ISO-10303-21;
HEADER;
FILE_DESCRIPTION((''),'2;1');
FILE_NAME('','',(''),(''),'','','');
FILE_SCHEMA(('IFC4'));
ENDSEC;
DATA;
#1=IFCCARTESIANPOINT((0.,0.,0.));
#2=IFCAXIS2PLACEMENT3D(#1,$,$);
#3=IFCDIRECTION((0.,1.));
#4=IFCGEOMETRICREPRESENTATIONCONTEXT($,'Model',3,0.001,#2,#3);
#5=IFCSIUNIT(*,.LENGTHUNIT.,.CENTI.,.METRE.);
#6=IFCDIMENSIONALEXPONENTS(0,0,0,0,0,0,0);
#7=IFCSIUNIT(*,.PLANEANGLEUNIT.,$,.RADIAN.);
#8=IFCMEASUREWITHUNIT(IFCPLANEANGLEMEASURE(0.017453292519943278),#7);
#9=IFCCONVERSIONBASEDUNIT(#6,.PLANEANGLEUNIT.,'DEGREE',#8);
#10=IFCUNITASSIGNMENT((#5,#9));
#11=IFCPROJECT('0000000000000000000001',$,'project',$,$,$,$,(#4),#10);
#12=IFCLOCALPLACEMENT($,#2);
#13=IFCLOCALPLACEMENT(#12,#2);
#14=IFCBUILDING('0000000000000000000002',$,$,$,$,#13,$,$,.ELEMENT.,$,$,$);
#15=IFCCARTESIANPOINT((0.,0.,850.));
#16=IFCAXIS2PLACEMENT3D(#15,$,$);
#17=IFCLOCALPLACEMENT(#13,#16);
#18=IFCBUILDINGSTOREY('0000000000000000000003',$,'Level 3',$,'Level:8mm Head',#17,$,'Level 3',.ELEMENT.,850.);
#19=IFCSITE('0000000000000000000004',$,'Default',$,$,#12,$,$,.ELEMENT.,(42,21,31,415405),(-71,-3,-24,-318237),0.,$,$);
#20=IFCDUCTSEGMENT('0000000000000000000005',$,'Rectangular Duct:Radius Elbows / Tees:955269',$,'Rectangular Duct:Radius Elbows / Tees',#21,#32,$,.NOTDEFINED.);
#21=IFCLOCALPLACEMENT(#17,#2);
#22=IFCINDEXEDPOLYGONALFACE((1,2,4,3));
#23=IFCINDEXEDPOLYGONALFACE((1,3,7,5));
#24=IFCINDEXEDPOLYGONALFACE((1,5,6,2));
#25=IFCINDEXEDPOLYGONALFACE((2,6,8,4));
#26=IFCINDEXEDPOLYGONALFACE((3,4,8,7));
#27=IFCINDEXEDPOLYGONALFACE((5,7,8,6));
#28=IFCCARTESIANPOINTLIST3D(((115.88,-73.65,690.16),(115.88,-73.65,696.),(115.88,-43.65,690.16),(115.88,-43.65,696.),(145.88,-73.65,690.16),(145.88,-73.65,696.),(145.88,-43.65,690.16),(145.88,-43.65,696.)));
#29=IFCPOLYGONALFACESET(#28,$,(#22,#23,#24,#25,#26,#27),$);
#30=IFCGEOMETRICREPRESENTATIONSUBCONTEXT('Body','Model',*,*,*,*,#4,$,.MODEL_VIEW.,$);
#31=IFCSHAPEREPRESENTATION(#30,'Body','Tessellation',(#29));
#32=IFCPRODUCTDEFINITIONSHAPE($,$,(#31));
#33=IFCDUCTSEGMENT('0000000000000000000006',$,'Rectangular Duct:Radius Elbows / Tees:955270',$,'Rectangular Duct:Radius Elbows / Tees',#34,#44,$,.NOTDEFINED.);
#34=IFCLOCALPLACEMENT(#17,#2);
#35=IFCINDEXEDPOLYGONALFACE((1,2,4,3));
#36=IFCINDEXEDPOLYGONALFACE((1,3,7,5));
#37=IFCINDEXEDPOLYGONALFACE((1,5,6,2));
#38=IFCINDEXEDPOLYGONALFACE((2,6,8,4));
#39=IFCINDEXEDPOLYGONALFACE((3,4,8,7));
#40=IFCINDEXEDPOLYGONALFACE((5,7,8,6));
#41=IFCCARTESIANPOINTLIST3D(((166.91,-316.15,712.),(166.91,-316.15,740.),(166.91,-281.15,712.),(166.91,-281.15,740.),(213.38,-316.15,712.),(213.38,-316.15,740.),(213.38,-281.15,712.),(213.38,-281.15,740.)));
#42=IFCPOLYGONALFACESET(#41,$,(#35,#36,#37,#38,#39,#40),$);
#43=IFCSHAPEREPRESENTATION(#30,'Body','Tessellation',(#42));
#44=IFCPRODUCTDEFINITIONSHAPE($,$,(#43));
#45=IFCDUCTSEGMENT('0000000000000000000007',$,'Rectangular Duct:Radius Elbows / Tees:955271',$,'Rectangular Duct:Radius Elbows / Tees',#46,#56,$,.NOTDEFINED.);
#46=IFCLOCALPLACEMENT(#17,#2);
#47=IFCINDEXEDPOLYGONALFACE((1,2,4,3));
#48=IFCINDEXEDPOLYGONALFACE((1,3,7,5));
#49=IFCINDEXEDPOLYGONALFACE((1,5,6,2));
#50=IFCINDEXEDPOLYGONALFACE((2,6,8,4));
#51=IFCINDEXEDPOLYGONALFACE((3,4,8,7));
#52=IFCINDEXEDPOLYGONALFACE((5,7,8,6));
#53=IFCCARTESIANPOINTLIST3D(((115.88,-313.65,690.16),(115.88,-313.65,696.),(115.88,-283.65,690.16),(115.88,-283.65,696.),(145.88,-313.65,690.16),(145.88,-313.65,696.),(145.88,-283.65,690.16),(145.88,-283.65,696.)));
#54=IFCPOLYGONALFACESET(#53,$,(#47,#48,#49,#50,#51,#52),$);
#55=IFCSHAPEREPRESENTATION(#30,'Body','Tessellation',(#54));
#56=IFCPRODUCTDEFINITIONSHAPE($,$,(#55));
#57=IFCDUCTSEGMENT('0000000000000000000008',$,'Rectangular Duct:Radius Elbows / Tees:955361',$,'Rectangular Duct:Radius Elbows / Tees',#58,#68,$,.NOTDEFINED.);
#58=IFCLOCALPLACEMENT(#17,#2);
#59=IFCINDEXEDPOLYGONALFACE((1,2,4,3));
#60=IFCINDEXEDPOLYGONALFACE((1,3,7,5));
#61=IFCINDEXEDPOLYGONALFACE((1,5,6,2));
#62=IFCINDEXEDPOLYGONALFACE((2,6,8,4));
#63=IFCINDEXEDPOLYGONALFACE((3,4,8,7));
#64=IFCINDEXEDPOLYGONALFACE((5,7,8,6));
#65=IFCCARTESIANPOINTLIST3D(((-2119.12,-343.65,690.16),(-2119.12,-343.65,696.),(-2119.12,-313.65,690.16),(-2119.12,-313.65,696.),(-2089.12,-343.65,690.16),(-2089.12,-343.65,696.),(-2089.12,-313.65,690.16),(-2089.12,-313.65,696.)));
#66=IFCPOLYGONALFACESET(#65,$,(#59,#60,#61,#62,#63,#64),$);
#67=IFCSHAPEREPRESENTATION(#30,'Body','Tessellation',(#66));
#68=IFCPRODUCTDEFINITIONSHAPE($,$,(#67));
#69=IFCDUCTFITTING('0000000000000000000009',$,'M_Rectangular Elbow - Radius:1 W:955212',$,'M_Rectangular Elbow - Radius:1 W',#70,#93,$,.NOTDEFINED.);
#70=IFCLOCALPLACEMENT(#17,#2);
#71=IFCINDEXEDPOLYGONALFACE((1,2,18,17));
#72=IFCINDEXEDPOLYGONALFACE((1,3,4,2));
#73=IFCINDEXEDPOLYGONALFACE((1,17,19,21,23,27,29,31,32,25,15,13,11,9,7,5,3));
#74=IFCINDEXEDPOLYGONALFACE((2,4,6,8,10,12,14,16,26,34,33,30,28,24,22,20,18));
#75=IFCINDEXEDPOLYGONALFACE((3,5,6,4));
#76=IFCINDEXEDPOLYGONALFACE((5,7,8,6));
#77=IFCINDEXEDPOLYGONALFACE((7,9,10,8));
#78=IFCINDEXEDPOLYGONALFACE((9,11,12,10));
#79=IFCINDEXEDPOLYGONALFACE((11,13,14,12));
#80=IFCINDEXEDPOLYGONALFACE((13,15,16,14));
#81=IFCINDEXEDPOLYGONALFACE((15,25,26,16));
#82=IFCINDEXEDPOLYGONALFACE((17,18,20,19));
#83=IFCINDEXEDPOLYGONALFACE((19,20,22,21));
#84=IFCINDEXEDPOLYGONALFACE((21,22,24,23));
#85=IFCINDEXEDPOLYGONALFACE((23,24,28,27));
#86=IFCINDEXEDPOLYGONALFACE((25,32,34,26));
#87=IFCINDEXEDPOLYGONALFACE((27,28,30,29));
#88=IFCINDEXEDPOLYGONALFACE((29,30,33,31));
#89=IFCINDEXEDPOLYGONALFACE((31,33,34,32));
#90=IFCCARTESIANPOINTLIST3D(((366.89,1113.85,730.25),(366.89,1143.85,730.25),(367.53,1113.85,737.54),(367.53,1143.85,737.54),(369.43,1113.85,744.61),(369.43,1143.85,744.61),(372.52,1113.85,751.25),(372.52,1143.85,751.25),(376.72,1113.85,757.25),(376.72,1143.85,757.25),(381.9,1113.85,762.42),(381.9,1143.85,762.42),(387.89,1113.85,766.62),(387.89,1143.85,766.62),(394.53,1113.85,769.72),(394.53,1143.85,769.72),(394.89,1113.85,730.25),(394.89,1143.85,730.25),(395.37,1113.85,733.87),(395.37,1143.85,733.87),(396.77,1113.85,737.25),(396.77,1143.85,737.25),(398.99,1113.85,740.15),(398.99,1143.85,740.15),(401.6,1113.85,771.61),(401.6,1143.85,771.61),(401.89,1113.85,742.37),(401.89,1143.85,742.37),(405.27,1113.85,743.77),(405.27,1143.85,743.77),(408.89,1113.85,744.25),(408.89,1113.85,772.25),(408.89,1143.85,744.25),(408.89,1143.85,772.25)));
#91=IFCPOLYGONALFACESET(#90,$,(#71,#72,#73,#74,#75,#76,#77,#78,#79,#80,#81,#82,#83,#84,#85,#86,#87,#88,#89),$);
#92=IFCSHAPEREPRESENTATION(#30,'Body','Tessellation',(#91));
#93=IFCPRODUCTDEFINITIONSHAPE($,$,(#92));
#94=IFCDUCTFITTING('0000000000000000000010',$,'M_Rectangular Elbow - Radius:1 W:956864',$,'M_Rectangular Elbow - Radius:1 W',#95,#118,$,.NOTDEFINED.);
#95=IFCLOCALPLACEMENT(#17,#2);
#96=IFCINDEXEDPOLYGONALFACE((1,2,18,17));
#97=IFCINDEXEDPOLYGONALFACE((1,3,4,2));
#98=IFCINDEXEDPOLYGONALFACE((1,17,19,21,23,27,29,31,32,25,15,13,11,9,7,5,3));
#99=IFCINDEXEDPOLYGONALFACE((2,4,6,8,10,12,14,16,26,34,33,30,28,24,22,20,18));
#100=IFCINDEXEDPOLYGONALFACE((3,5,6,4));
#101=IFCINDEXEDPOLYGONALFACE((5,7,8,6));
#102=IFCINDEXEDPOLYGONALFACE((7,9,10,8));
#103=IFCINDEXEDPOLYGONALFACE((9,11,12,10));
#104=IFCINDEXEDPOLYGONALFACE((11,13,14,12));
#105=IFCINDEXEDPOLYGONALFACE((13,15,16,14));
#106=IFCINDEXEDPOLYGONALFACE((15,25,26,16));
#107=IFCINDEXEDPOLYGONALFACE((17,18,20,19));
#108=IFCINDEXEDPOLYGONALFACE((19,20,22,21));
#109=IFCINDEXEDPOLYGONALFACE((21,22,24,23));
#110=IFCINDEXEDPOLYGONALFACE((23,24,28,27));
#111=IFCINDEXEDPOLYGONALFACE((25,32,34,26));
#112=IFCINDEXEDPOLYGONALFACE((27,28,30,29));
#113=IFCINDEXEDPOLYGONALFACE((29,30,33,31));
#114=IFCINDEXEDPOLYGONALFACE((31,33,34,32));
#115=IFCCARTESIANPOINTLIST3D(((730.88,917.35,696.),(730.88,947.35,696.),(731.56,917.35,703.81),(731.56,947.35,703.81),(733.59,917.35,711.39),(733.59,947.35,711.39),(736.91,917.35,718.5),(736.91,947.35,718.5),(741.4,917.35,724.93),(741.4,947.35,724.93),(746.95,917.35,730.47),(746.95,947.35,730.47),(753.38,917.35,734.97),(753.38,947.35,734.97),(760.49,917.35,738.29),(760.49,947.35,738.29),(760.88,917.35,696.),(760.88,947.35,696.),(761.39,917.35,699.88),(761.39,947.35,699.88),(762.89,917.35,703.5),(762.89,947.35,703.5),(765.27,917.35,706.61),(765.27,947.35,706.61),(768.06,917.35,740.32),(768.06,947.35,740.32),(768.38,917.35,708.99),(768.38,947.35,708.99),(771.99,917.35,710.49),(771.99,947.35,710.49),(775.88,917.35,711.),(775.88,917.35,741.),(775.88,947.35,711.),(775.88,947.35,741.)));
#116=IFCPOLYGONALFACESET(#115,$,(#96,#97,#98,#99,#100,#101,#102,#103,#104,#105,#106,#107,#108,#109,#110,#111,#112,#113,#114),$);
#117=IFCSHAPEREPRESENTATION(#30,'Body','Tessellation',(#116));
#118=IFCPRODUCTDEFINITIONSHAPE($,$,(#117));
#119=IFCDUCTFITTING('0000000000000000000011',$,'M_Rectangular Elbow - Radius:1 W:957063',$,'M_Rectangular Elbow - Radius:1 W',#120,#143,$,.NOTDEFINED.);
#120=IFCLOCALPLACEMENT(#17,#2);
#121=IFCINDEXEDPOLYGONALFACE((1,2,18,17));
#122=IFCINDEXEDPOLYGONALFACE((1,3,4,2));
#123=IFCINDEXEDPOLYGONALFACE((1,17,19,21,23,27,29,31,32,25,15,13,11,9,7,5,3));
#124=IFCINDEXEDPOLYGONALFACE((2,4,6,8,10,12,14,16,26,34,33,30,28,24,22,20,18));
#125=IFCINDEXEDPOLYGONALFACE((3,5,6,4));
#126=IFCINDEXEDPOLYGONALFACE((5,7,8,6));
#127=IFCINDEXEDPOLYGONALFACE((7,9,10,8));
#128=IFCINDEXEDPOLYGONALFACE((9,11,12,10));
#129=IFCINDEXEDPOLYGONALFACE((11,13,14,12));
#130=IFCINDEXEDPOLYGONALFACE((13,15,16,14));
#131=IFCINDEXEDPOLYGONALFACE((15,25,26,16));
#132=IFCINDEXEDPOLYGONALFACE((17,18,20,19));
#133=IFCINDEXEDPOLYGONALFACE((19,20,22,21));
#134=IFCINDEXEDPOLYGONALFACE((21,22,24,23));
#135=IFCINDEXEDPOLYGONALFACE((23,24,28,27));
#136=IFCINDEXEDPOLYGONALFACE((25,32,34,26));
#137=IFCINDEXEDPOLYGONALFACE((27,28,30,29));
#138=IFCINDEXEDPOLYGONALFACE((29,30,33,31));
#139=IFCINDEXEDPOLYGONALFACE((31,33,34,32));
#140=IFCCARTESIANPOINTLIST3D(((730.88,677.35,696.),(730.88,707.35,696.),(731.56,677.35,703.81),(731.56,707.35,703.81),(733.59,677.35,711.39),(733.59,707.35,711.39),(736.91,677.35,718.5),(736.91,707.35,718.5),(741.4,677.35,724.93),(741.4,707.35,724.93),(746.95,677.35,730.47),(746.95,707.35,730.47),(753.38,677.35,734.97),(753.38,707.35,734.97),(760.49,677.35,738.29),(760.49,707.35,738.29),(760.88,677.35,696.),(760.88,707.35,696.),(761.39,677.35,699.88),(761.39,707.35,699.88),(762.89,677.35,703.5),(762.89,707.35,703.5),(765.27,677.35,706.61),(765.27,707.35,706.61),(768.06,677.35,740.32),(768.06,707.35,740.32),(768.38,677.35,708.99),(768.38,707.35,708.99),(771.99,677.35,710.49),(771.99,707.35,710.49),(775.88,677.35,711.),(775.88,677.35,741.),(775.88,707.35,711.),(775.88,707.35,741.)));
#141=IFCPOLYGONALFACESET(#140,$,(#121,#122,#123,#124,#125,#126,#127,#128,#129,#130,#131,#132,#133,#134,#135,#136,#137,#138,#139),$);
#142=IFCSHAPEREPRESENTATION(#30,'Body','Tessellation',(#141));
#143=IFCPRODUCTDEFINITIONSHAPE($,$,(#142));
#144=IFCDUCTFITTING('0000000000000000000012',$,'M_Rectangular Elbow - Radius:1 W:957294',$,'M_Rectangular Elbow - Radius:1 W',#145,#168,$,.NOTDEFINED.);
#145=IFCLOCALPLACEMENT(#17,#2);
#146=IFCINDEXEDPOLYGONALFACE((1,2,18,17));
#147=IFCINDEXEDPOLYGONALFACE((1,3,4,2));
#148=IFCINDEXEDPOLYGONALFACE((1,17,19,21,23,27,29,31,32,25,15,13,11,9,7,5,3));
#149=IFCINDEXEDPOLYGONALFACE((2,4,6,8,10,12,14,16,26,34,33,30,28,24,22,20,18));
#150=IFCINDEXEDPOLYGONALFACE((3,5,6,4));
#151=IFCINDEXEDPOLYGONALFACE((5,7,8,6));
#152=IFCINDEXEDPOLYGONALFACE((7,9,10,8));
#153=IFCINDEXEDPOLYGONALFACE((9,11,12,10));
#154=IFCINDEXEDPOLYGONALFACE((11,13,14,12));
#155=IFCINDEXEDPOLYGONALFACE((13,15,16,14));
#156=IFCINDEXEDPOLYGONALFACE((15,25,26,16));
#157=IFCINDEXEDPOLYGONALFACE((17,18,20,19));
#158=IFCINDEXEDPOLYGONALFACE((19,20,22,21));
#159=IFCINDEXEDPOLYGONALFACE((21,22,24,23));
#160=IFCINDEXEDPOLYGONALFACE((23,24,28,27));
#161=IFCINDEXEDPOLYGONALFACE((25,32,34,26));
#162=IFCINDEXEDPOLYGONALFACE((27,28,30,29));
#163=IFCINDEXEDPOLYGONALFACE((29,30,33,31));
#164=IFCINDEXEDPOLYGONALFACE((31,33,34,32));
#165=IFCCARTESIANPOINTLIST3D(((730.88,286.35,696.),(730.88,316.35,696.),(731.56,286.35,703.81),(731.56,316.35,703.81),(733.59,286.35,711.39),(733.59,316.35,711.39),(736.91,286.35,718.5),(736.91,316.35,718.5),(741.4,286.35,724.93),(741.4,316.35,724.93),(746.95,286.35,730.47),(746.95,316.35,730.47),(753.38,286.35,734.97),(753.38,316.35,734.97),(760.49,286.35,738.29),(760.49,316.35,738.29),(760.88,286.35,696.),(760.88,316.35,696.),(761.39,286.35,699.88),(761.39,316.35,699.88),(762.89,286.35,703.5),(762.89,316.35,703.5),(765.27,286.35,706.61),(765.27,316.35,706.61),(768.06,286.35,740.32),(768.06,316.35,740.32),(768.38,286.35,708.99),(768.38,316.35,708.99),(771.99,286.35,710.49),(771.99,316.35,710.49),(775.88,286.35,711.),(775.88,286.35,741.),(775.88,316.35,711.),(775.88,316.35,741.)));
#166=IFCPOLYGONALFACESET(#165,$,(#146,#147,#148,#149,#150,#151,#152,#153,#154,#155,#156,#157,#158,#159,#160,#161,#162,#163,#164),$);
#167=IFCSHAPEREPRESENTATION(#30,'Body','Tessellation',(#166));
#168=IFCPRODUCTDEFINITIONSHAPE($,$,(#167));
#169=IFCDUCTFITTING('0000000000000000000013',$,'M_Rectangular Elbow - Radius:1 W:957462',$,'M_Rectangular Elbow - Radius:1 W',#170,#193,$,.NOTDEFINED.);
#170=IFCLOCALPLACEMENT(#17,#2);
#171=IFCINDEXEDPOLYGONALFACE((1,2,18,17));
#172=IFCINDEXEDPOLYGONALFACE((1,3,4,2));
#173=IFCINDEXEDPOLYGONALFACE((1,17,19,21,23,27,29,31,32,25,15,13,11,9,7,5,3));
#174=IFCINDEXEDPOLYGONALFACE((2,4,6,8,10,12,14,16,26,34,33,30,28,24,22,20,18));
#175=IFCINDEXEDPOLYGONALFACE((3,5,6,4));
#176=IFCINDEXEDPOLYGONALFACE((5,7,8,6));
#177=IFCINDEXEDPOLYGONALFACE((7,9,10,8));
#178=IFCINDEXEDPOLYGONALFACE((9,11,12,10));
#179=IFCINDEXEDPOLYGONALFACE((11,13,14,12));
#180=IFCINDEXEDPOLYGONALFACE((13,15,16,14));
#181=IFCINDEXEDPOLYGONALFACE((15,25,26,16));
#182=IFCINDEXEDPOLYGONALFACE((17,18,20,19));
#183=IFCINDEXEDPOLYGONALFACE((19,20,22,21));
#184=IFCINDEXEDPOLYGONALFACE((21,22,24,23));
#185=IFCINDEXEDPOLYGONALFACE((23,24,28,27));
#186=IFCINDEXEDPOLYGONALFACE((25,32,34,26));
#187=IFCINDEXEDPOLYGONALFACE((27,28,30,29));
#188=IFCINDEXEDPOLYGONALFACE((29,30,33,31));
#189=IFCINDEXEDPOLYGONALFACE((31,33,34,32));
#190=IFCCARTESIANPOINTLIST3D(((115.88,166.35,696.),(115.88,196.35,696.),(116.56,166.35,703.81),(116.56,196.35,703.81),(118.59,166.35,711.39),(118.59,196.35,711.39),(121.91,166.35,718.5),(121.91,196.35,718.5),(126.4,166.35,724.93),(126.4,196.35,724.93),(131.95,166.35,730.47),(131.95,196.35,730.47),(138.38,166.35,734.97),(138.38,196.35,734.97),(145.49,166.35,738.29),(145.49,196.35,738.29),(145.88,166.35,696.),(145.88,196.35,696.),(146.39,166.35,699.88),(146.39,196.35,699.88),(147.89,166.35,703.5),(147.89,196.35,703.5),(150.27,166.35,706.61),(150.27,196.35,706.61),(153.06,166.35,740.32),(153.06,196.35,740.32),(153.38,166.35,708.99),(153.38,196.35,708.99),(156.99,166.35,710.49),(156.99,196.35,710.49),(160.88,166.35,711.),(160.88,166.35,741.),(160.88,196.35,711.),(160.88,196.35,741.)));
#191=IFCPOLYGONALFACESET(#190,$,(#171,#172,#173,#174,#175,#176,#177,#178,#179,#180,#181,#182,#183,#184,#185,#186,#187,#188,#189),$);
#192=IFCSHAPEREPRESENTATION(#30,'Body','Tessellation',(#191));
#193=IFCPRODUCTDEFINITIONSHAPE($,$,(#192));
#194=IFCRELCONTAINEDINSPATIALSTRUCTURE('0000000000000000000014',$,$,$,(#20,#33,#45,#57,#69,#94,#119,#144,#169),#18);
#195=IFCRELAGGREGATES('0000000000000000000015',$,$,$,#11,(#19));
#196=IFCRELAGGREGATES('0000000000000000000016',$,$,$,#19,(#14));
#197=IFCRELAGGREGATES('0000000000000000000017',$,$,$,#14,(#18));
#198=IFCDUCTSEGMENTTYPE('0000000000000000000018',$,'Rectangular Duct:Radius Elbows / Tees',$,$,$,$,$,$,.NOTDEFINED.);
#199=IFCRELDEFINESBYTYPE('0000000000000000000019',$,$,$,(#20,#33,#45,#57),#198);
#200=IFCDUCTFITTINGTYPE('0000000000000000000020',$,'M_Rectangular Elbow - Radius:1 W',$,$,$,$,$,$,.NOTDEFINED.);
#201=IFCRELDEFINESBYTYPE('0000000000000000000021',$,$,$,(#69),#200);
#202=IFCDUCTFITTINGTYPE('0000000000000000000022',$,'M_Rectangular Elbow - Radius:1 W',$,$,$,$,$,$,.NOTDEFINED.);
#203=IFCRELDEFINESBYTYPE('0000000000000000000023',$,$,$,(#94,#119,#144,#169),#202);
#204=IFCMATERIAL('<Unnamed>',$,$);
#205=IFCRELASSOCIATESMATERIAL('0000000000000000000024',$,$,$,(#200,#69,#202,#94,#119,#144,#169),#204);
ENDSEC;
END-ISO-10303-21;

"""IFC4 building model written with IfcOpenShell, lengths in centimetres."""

from ifc_helpers import new_model, entity, si_unit, converted_unit, direction, frame, origin, place, context, subcontext, project, spatial, line, arc, indexed_curve, outline, extrude, source, transform, mapped, material, type_object, type_shapes, element, save


model = new_model("IFC4")

# Units and contexts
model_context = context("Model", 3, precision=0.001, world=origin(), true_north=direction((0.0, 1.0)))
body_context = subcontext(model_context, "Body", "Model", "MODEL_VIEW")
ifc_project = project(units=[si_unit("LENGTHUNIT", "METRE", prefix="CENTI"), converted_unit("PLANEANGLEUNIT", "DEGREE", entity("IfcPlaneAngleMeasure", 0.017453292519943278), si_unit("PLANEANGLEUNIT", "RADIAN"), dimensions=[0, 0, 0, 0, 0, 0, 0])], contexts=[model_context])

# Site, building, storey
site_placement = place(None, origin())
site = spatial("IfcSite", under=ifc_project, at=site_placement, Name="Default", CompositionType="ELEMENT", RefLatitude=(42, 21, 31, 415405), RefLongitude=(-71, -3, -24, -318237), RefElevation=0.0)
building_placement = place(site_placement, origin())
building = spatial("IfcBuilding", under=site, at=building_placement, CompositionType="ELEMENT")
storey_placement = place(building_placement, frame((0.0, 0.0, 850.0)))
storey = spatial("IfcBuildingStorey", under=building, at=storey_placement, Name="Level 3", ObjectType="Level:8mm Head", LongName="Level 3", CompositionType="ELEMENT", Elevation=850.0)

# Duct segments
duct_segment_type_1 = type_object("IfcDuctSegmentType", Name="Rectangular Duct:Radius Elbows / Tees", PredefinedType="NOTDEFINED")
duct_segment_1_placement = place(storey_placement, origin())
element("IfcDuctSegment", 1, at=duct_segment_1_placement, inside=storey, type_object=duct_segment_type_1, Name="Rectangular Duct:Radius Elbows / Tees:955269", ObjectType="Rectangular Duct:Radius Elbows / Tees", PredefinedType="NOTDEFINED", context=body_context, shape_type="SweptSolid", body=[
    extrude(outline(indexed_curve([(-15.0, -15.0), (15.0, -15.0), (15.0, 15.0), (-15.0, 15.0), (-15.0, -15.0)], self_intersect=False)), frame((130.88, -58.65, 690.16)), (0.0, 0.0, 1.0), 5.84),
])
duct_segment_2_placement = place(storey_placement, origin())
element("IfcDuctSegment", 2, at=duct_segment_2_placement, inside=storey, type_object=duct_segment_type_1, Name="Rectangular Duct:Radius Elbows / Tees:955270", ObjectType="Rectangular Duct:Radius Elbows / Tees", PredefinedType="NOTDEFINED", context=body_context, shape_type="SweptSolid", body=[
    extrude(outline(indexed_curve([(-23.23, -17.5), (23.23, -17.5), (23.23, 17.5), (-23.23, 17.5), (-23.23, -17.5)], self_intersect=False)), frame((190.14, -298.65, 712.0)), (0.0, 0.0, 1.0), 28.0),
])
duct_segment_3_placement = place(storey_placement, origin())
element("IfcDuctSegment", 3, at=duct_segment_3_placement, inside=storey, type_object=duct_segment_type_1, Name="Rectangular Duct:Radius Elbows / Tees:955271", ObjectType="Rectangular Duct:Radius Elbows / Tees", PredefinedType="NOTDEFINED", context=body_context, shape_type="SweptSolid", body=[
    extrude(outline(indexed_curve([(-15.0, -15.0), (15.0, -15.0), (15.0, 15.0), (-15.0, 15.0), (-15.0, -15.0)], self_intersect=False)), frame((130.88, -298.65, 690.16)), (0.0, 0.0, 1.0), 5.84),
])
duct_segment_4_placement = place(storey_placement, origin())
element("IfcDuctSegment", 4, at=duct_segment_4_placement, inside=storey, type_object=duct_segment_type_1, Name="Rectangular Duct:Radius Elbows / Tees:955361", ObjectType="Rectangular Duct:Radius Elbows / Tees", PredefinedType="NOTDEFINED", context=body_context, shape_type="SweptSolid", body=[
    extrude(outline(indexed_curve([(-15.0, -15.0), (15.0, -15.0), (15.0, 15.0), (-15.0, 15.0), (-15.0, -15.0)], self_intersect=False)), frame((-2104.12, -328.65, 690.16), z_axis=(0.0, 0.0, 1.0), x_axis=(0.0, -1.0, 0.0)), (0.0, 0.0, 1.0), 5.84),
])

# Duct fittings
ifc_material = material(Name="<Unnamed>")
duct_fitting_type_1 = type_object("IfcDuctFittingType", Name="M_Rectangular Elbow - Radius:1 W", PredefinedType="NOTDEFINED", material=ifc_material)
shared_shape_1 = source(origin(), body_context, "Body", "SweptSolid", [
    extrude(outline(indexed_curve([(-28.0, -14.0), (0.0, -14.0), (4.1, -4.1), (14.0, 0.0), (14.0, 28.0), (-15.7, 15.7)], segments=[line(1, 2), arc(2, 3, 4), line(4, 5), arc(5, 6, 1)], self_intersect=False)), frame((-14.0, 14.0, -15.0), z_axis=(0.0, 0.0, 1.0), x_axis=(-1.0, 0.0, 0.0)), (0.0, 0.0, 1.0), 30.0),
])
type_shapes(duct_fitting_type_1, [shared_shape_1])
duct_fitting_1_placement = place(storey_placement, frame((380.89, 1128.85, 758.25), z_axis=(0.0, 1.0, 0.0), x_axis=(0.0, 0.0, 1.0)))
element("IfcDuctFitting", 5, at=duct_fitting_1_placement, inside=storey, type_object=duct_fitting_type_1, material=ifc_material, Name="M_Rectangular Elbow - Radius:1 W:955212", ObjectType="M_Rectangular Elbow - Radius:1 W", PredefinedType="NOTDEFINED", context=body_context, shape_type="MappedRepresentation", body=[
    mapped(shared_shape_1, transform((0.0, 0.0, 0.0), scale=1.0)),
])
duct_fitting_type_2 = type_object("IfcDuctFittingType", Name="M_Rectangular Elbow - Radius:1 W", PredefinedType="NOTDEFINED", material=ifc_material)
shared_shape_2 = source(origin(), body_context, "Body", "SweptSolid", [
    extrude(outline(indexed_curve([(-30.0, -15.0), (0.0, -15.0), (4.39, -4.39), (15.0, 0.0), (15.0, 30.0), (-16.82, 16.82)], segments=[line(1, 2), arc(2, 3, 4), line(4, 5), arc(5, 6, 1)], self_intersect=False)), frame((-15.0, 15.0, -15.0), z_axis=(0.0, 0.0, 1.0), x_axis=(-1.0, 0.0, 0.0)), (0.0, 0.0, 1.0), 30.0),
])
type_shapes(duct_fitting_type_2, [shared_shape_2])
for number, where, z_axis, x_axis, name in (
    (6, (745.88, 932.35, 726.0), (0.0, -1.0, 0.0), (-1.0, 0.0, 0.0), "M_Rectangular Elbow - Radius:1 W:956864"),
    (7, (745.88, 692.35, 726.0), (0.0, -1.0, 0.0), (-1.0, 0.0, 0.0), "M_Rectangular Elbow - Radius:1 W:957063"),
    (8, (745.88, 301.35, 726.0), (0.0, -1.0, 0.0), (-1.0, 0.0, 0.0), "M_Rectangular Elbow - Radius:1 W:957294"),
    (9, (130.88, 181.35, 726.0), (0.0, -1.0, 0.0), (-1.0, 0.0, 0.0), "M_Rectangular Elbow - Radius:1 W:957462"),
):
    element("IfcDuctFitting", number, at=place(storey_placement, frame(where, z_axis=z_axis, x_axis=x_axis)), inside=storey, type_object=duct_fitting_type_2, material=ifc_material, Name=name, ObjectType="M_Rectangular Elbow - Radius:1 W", PredefinedType="NOTDEFINED", context=body_context, shape_type="MappedRepresentation", body=[
        mapped(shared_shape_2, transform((0.0, 0.0, 0.0), scale=1.0)),
    ])

save(model, "model.ifc")
